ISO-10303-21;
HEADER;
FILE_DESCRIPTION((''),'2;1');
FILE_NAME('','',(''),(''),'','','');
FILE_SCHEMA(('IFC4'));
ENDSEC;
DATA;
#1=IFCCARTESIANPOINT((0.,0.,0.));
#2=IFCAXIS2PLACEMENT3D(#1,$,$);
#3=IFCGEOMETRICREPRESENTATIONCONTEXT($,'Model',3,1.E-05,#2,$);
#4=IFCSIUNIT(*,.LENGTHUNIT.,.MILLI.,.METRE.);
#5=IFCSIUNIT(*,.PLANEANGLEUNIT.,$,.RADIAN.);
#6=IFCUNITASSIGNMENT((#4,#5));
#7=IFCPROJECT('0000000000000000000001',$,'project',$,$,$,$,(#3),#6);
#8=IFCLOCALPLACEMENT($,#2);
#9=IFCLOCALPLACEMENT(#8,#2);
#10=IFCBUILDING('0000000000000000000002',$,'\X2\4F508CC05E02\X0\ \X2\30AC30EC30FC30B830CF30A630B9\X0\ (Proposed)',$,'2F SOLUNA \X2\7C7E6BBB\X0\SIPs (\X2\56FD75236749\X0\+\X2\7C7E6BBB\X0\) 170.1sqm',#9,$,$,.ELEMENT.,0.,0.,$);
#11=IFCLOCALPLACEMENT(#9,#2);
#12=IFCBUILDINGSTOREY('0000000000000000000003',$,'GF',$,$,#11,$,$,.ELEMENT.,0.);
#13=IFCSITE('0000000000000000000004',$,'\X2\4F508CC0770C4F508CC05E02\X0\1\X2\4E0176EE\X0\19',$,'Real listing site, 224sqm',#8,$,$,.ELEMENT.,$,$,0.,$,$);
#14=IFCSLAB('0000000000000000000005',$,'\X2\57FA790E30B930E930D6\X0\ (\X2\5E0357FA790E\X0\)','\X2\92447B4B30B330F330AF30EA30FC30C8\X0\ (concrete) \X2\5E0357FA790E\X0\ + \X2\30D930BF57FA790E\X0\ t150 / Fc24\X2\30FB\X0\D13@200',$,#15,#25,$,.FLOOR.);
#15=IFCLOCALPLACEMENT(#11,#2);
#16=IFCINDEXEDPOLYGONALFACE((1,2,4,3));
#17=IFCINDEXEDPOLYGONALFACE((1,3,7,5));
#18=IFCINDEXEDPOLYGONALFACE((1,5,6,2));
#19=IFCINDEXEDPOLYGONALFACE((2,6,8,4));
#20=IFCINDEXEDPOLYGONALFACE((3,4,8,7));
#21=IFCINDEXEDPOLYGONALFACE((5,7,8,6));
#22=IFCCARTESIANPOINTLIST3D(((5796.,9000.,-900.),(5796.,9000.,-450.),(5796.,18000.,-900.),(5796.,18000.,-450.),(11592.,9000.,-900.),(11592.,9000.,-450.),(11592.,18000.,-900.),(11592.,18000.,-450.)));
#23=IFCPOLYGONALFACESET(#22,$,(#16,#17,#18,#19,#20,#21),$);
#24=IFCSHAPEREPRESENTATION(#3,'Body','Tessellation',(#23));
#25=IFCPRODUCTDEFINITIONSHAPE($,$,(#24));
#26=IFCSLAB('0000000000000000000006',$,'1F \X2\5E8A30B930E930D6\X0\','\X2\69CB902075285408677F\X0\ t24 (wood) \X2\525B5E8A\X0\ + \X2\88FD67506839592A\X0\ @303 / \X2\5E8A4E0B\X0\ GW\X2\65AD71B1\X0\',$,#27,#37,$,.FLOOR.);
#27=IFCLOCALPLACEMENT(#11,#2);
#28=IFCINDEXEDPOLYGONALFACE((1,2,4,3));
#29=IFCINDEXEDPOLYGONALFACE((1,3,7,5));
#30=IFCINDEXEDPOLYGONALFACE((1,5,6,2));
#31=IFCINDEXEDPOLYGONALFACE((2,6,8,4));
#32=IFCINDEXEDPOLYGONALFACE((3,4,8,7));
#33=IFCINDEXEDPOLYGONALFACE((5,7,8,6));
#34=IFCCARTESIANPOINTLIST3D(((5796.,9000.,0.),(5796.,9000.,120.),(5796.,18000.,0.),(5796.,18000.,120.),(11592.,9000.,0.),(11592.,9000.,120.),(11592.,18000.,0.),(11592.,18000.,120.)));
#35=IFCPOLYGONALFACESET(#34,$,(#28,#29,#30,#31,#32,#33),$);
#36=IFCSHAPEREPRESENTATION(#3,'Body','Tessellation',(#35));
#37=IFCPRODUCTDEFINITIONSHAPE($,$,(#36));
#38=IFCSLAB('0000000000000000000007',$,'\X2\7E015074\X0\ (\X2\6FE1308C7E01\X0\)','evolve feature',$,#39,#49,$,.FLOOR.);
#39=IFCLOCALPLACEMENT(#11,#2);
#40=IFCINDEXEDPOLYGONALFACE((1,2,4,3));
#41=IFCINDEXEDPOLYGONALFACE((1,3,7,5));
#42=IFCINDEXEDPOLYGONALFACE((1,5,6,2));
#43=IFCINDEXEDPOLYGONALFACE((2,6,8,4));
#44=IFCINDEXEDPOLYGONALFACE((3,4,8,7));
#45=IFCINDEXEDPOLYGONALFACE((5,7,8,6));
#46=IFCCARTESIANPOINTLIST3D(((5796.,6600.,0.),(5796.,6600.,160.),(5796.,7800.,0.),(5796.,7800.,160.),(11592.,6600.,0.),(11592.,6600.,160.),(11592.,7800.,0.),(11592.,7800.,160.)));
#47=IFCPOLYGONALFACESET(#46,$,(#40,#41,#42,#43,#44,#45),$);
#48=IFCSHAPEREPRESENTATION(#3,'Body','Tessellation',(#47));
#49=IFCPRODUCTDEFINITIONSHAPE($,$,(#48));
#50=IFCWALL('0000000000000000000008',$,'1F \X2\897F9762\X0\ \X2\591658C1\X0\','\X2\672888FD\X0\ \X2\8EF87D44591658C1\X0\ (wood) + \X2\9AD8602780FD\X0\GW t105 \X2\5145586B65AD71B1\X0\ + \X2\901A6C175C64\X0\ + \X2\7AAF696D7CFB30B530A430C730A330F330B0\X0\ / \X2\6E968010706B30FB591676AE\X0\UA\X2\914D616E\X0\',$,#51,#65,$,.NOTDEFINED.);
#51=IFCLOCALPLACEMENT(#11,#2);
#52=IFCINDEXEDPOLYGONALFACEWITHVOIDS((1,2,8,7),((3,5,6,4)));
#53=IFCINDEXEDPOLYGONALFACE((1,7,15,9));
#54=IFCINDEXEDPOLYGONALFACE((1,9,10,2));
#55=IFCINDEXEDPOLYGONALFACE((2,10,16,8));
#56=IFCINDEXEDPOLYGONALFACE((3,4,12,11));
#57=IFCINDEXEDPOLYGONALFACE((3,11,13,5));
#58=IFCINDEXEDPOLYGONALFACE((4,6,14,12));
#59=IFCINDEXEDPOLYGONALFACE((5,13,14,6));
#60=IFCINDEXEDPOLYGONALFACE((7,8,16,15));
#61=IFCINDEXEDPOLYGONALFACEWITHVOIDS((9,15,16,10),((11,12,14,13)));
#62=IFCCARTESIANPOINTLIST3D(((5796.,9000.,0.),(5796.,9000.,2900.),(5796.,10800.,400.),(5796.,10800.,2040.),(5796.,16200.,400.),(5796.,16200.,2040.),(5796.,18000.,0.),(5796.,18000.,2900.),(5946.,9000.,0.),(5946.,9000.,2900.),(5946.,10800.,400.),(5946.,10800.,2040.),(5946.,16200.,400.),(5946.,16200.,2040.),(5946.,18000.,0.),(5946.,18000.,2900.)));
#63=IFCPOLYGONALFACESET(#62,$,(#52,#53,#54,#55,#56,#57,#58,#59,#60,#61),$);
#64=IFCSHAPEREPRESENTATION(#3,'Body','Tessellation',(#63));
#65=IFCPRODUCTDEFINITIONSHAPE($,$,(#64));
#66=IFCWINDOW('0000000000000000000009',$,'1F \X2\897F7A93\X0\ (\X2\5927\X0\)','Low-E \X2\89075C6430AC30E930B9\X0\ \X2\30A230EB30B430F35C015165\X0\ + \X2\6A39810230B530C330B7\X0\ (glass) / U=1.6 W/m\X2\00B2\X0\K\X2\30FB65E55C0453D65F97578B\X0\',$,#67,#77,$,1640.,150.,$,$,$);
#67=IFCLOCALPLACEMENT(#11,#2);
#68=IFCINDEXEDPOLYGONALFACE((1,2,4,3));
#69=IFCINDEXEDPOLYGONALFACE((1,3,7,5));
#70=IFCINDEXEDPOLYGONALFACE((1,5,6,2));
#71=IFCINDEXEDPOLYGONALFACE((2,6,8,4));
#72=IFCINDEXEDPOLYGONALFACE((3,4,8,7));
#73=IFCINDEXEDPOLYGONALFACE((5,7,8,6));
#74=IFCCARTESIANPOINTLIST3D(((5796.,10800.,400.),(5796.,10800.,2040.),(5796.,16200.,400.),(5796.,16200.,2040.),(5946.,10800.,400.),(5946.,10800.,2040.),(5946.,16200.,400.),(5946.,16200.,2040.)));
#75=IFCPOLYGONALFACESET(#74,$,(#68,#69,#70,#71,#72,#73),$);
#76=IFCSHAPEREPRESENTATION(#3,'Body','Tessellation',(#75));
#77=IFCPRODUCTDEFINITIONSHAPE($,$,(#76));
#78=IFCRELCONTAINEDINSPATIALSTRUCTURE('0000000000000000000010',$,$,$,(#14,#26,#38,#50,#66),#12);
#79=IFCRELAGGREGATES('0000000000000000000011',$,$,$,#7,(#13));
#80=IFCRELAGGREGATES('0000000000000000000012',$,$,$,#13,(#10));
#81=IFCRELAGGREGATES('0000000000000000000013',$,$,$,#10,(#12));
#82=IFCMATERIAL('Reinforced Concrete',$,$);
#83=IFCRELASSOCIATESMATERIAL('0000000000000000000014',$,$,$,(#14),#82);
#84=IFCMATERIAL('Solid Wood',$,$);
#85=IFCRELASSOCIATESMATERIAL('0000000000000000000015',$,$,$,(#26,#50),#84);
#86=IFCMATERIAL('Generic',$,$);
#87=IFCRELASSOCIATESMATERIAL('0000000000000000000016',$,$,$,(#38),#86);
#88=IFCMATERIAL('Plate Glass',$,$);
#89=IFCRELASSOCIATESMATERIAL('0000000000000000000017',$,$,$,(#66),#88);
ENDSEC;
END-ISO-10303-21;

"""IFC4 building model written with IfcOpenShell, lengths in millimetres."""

from ifc_helpers import new_model, si_unit, frame, frame_2d, origin, place, context, project, spatial, rectangle, extrude, material, element, fill, save


model = new_model("IFC4")

# Units and contexts
model_context = context("Model", 3, precision=1e-05, world=origin())
ifc_project = project(units=[si_unit("LENGTHUNIT", "METRE", prefix="MILLI"), si_unit("PLANEANGLEUNIT", "RADIAN")], contexts=[model_context])

# Site, building, storey
site_placement = place(None, origin())
site = spatial("IfcSite", under=ifc_project, at=site_placement, Name="佐賀県佐賀市1丁目19", ObjectType="Real listing site, 224sqm", CompositionType="ELEMENT", RefElevation=0.0)
building_placement = place(site_placement, origin())
building = spatial("IfcBuilding", under=site, at=building_placement, Name="佐賀市 ガレージハウス (Proposed)", ObjectType="2F SOLUNA 籾殻SIPs (国産杉+籾殻) 170.1sqm", CompositionType="ELEMENT", ElevationOfRefHeight=0.0, ElevationOfTerrain=0.0)
storey_placement = place(building_placement, origin())
storey = spatial("IfcBuildingStorey", under=building, at=storey_placement, Name="GF", CompositionType="ELEMENT", Elevation=0.0)

# Slabs
ifc_material_1 = material(Name="Reinforced Concrete")
slab_1_placement = place(storey_placement, frame((2898.0, 4500.0, -450.0)))
element("IfcSlab", 1, at=slab_1_placement, inside=storey, material=ifc_material_1, Name="基礎スラブ (布基礎)", Description="鉄筋コンクリート (concrete) 布基礎 + ベタ基礎 t150 / Fc24・D13@200", PredefinedType="FLOOR", context=model_context, shape_type="SweptSolid", body=[
    extrude(rectangle(XDim=5796.0, YDim=9000.0, at=frame_2d((2898.0, 4500.0))), frame((2898.0, 4500.0, -450.0)), (0.0, 0.0, 1.0), 450.0),
])
ifc_material_2 = material(Name="Solid Wood")
slab_2_placement = place(storey_placement, frame((2898.0, 4500.0, 0.0)))
element("IfcSlab", 2, at=slab_2_placement, inside=storey, material=ifc_material_2, Name="1F 床スラブ", Description="構造用合板 t24 (wood) 剛床 + 製材根太 @303 / 床下 GW断熱", PredefinedType="FLOOR", context=model_context, shape_type="SweptSolid", body=[
    extrude(rectangle(XDim=5796.0, YDim=9000.0, at=frame_2d((2898.0, 4500.0))), frame((2898.0, 4500.0, 0.0)), (0.0, 0.0, 1.0), 120.0),
])
ifc_material_3 = material(Name="Generic")
slab_3_placement = place(storey_placement, frame((2898.0, 3300.0, 0.0)))
element("IfcSlab", 3, at=slab_3_placement, inside=storey, material=ifc_material_3, Name="縁側 (濡れ縁)", Description="evolve feature", PredefinedType="FLOOR", context=model_context, shape_type="SweptSolid", body=[
    extrude(rectangle(XDim=5796.0, YDim=1200.0, at=frame_2d((2898.0, 600.0))), frame((2898.0, 3300.0, 0.0)), (0.0, 0.0, 1.0), 160.0),
])

# Shared definitions
ifc_material_4 = material(Name="Plate Glass")

# Wall, opening, window
wall_1_placement = place(storey_placement, frame((2898.0, 4500.0, 0.0)))
wall_1 = element("IfcWall", 4, at=wall_1_placement, inside=storey, material=ifc_material_2, Name="1F 西面 外壁", Description="木製 軸組外壁 (wood) + 高性能GW t105 充填断熱 + 通気層 + 窯業系サイディング / 準耐火・外皮UA配慮", PredefinedType="NOTDEFINED", context=model_context, shape_type="SweptSolid", body=[
    extrude(rectangle(XDim=150.0, YDim=9000.0, at=frame_2d((75.0, 4500.0))), frame((2898.0, 4500.0, 0.0)), (0.0, 0.0, 1.0), 2900.0),
])
opening_1_placement = place(storey_placement, frame((2898.0, 5400.0, 200.0)))
opening_1 = element("IfcOpeningElement", 5, at=opening_1_placement, cuts=wall_1, PredefinedType="NOTDEFINED", context=model_context, shape_type="SweptSolid", body=[
    extrude(rectangle(XDim=150.0, YDim=5400.0, at=frame_2d((75.0, 2700.0))), frame((2898.0, 5400.0, 200.0)), (0.0, 0.0, 1.0), 1640.0),
])
window_1_placement = place(storey_placement, frame((2898.0, 5400.0, 200.0)))
window_1 = element("IfcWindow", 6, at=window_1_placement, inside=storey, material=ifc_material_4, Name="1F 西窓 (大)", Description="Low-E 複層ガラス アルゴン封入 + 樹脂サッシ (glass) / U=1.6 W/m²K・日射取得型", OverallHeight=1640.0, OverallWidth=150.0, context=model_context, shape_type="SweptSolid", body=[
    extrude(rectangle(XDim=150.0, YDim=5400.0, at=frame_2d((75.0, 2700.0))), frame((2898.0, 5400.0, 200.0)), (0.0, 0.0, 1.0), 1640.0),
])
fill(opening_1, window_1)

save(model, "model.ifc")
